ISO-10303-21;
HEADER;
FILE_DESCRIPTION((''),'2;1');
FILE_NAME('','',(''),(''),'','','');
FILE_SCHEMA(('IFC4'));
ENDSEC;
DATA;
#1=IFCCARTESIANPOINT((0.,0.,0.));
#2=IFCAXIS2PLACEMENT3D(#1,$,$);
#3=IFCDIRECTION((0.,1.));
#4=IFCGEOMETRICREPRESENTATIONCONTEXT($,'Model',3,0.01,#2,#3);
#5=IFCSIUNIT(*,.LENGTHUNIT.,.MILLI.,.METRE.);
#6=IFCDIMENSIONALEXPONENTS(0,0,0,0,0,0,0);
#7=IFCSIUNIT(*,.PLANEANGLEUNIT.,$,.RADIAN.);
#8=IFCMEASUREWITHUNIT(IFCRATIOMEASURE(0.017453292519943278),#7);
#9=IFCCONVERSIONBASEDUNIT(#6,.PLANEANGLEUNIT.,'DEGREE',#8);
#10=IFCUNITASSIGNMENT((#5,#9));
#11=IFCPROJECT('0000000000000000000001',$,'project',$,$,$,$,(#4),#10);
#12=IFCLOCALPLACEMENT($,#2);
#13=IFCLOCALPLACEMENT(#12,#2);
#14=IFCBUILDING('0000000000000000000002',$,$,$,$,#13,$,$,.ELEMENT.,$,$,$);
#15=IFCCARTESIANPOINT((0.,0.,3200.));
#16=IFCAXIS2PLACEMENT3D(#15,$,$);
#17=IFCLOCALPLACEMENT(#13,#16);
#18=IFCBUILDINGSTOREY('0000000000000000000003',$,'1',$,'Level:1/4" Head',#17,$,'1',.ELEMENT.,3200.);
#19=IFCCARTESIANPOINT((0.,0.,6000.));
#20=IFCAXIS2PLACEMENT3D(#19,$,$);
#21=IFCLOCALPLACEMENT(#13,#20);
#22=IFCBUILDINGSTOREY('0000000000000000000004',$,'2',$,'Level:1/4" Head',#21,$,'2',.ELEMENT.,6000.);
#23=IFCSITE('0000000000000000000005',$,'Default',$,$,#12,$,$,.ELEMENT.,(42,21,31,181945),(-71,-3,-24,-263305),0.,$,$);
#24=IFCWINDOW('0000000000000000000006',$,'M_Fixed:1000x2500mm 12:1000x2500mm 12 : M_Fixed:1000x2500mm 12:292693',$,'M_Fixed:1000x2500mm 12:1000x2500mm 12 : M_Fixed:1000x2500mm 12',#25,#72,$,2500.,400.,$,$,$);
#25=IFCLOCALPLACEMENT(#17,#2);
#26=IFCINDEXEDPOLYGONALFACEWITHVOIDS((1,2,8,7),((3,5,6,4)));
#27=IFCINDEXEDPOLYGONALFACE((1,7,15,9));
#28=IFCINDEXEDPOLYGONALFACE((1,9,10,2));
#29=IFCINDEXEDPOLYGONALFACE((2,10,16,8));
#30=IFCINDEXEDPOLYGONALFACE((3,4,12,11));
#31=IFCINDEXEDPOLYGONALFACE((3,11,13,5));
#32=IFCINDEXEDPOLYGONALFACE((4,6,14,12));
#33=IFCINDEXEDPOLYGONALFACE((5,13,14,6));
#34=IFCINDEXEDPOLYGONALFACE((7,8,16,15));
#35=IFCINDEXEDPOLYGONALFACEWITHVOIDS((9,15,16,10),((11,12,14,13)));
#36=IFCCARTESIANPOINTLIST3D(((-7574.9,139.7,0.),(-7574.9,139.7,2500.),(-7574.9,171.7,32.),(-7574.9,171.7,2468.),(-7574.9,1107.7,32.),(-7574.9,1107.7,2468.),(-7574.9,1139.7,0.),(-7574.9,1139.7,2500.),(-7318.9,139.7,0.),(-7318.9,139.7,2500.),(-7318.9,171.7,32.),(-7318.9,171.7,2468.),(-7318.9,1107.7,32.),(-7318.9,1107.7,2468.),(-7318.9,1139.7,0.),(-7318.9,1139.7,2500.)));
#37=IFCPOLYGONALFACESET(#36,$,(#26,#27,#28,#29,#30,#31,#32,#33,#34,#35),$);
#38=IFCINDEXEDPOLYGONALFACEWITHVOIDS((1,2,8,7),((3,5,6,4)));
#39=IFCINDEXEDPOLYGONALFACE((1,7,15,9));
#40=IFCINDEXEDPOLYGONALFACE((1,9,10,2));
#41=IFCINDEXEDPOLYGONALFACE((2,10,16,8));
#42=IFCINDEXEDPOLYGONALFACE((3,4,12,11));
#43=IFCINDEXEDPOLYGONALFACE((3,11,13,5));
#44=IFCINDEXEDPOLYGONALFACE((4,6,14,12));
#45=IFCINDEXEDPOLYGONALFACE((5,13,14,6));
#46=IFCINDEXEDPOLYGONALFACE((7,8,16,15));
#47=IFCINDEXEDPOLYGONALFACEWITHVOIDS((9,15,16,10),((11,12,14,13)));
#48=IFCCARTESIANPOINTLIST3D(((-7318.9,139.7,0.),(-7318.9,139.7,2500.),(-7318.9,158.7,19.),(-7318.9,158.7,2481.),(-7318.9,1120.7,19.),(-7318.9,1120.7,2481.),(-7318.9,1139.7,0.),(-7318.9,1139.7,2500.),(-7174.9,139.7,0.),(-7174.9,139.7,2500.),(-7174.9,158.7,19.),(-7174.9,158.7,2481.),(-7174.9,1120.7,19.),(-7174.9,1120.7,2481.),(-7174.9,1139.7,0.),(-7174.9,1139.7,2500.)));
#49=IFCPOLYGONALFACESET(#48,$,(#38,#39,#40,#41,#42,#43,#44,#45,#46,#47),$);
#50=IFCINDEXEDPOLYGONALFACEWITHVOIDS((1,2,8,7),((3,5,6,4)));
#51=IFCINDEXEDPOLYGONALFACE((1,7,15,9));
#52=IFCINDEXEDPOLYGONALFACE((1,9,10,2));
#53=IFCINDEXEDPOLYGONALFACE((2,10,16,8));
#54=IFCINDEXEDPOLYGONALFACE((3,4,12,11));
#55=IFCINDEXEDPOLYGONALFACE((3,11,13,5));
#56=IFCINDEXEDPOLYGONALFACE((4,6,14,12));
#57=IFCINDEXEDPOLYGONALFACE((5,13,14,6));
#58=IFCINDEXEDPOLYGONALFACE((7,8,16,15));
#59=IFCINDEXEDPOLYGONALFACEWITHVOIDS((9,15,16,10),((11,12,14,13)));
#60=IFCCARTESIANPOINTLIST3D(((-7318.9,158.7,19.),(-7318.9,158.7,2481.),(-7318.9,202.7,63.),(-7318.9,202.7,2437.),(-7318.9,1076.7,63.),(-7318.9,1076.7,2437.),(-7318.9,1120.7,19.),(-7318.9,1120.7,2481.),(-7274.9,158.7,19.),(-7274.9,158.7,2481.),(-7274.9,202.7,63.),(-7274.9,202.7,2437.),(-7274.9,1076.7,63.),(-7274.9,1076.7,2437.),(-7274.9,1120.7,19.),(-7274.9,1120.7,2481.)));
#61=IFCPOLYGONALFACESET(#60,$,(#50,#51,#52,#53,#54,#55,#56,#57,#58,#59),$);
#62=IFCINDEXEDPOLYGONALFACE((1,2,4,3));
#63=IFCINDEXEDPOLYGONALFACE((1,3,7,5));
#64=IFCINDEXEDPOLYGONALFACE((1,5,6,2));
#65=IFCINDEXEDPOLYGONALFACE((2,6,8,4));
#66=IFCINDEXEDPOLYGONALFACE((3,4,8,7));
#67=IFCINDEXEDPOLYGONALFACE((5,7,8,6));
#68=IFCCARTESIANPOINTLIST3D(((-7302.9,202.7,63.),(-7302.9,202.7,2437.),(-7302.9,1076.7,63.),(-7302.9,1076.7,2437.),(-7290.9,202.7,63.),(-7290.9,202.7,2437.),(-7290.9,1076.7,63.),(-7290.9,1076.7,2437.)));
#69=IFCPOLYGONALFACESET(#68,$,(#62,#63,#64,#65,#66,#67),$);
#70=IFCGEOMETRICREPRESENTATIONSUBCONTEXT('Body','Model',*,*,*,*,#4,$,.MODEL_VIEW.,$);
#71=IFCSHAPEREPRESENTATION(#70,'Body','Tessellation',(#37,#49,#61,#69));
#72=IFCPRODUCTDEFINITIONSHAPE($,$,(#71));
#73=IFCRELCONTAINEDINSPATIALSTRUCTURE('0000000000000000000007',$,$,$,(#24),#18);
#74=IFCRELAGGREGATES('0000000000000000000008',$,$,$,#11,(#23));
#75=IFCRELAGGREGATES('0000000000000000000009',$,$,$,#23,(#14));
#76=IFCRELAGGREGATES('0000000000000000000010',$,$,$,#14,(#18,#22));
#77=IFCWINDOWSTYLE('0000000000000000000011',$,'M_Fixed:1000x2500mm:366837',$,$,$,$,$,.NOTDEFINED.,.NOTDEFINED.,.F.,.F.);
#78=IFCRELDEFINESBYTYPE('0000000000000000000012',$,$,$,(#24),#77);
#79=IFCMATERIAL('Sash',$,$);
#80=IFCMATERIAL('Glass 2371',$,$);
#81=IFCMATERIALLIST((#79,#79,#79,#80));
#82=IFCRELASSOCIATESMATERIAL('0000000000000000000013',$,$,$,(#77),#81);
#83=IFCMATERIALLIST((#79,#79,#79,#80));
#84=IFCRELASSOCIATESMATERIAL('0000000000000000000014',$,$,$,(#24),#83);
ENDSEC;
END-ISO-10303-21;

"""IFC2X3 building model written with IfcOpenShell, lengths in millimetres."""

from ifc_helpers import new_model, entity, si_unit, converted_unit, direction, frame, frame_2d, origin, place, context, subcontext, project, spatial, polyline, rectangle, outline, extrude, source, transform, mapped, material, material_list, type_object, type_shapes, element, save


model = new_model("IFC2X3")

# Units and contexts
model_context = context("Model", 3, precision=0.01, world=origin(), true_north=direction((0.0, 1.0)))
body_context = subcontext(model_context, "Body", "Model", "MODEL_VIEW")
ifc_project = project(units=[si_unit("LENGTHUNIT", "METRE", prefix="MILLI"), converted_unit("PLANEANGLEUNIT", "DEGREE", entity("IfcRatioMeasure", 0.017453292519943278), si_unit("PLANEANGLEUNIT", "RADIAN"), dimensions=[0, 0, 0, 0, 0, 0, 0])], contexts=[model_context])

# Site, building, storey
site_placement = place(None, origin())
site = spatial("IfcSite", under=ifc_project, at=site_placement, Name="Default", CompositionType="ELEMENT", RefLatitude=(42, 21, 31, 181945), RefLongitude=(-71, -3, -24, -263305), RefElevation=0.0)
building_placement = place(site_placement, origin())
building = spatial("IfcBuilding", under=site, at=building_placement, CompositionType="ELEMENT")
storey_1_placement = place(building_placement, frame((0.0, 0.0, 3200.0)))
storey_1 = spatial("IfcBuildingStorey", under=building, at=storey_1_placement, Name="1", ObjectType="Level:1/4\" Head", LongName="1", CompositionType="ELEMENT", Elevation=3200.0)

# Shared definitions
storey_2_placement = place(building_placement, frame((0.0, 0.0, 6000.0)))
storey_2 = spatial("IfcBuildingStorey", under=building, at=storey_2_placement, Name="2", ObjectType="Level:1/4\" Head", LongName="2", CompositionType="ELEMENT", Elevation=6000.0)

# Shared definitions
ifc_material_1 = material(Name="Sash")
ifc_material_2 = material(Name="Glass 2371")

# Window
ifc_material_list_1 = material_list([ifc_material_1, ifc_material_1, ifc_material_1, ifc_material_2])
ifc_material_list_2 = material_list([ifc_material_1, ifc_material_1, ifc_material_1, ifc_material_2])
window_style_1 = type_object("IfcWindowStyle", Name="M_Fixed:1000x2500mm:366837", ConstructionType="NOTDEFINED", OperationType="NOTDEFINED", ParameterTakesPrecedence=False, Sizeable=False, material=ifc_material_list_2)
shared_shape_1 = source(origin(), body_context, "Body", "SweptSolid", [
    extrude(outline(polyline([(-1250.0, -500.0), (1250.0, -500.0), (1250.0, 500.0), (-1250.0, 500.0), (-1250.0, -500.0)]), holes=[polyline([(1218.0, 468.0), (1218.0, -468.0), (-1218.0, -468.0), (-1218.0, 468.0), (1218.0, 468.0)])]), frame((-7574.9, 639.7, 4450.0), z_axis=(1.0, 0.0, 0.0), x_axis=(0.0, 0.0, -1.0)), (0.0, 0.0, 1.0), 256.0),
    extrude(outline(polyline([(-1250.0, -500.0), (1250.0, -500.0), (1250.0, 500.0), (-1250.0, 500.0), (-1250.0, -500.0)]), holes=[polyline([(1231.0, 481.0), (1231.0, -481.0), (-1231.0, -481.0), (-1231.0, 481.0), (1231.0, 481.0)])]), frame((-7318.9, 639.7, 4450.0), z_axis=(1.0, 0.0, 0.0), x_axis=(0.0, 0.0, -1.0)), (0.0, 0.0, 1.0), 144.0),
    extrude(outline(polyline([(-1231.0, -481.0), (1231.0, -481.0), (1231.0, 481.0), (-1231.0, 481.0), (-1231.0, -481.0)]), holes=[polyline([(1187.0, 437.0), (1187.0, -437.0), (-1187.0, -437.0), (-1187.0, 437.0), (1187.0, 437.0)])]), frame((-7318.9, 639.7, 4450.0), z_axis=(1.0, 0.0, 0.0), x_axis=(0.0, 0.0, -1.0)), (0.0, 0.0, 1.0), 44.0),
    extrude(rectangle(XDim=874.0, YDim=12.0, at=frame_2d((0.0, 0.0), x_axis=(1.0, 0.0))), frame((-7296.9, 639.7, 3263.0), z_axis=(0.0, 0.0, 1.0), x_axis=(0.0, -1.0, 0.0)), (0.0, 0.0, 1.0), 2374.0),
])
type_shapes(window_style_1, [shared_shape_1])
window_1_placement = place(storey_1_placement, frame((0.0, 0.0, -3200.0)))
element("IfcWindow", 1, at=window_1_placement, inside=storey_1, type_object=window_style_1, material=ifc_material_list_1, Name="M_Fixed:1000x2500mm 12:1000x2500mm 12 : M_Fixed:1000x2500mm 12:292693", ObjectType="M_Fixed:1000x2500mm 12:1000x2500mm 12 : M_Fixed:1000x2500mm 12", OverallHeight=2500.0, OverallWidth=400.0, context=body_context, shape_type="MappedRepresentation", body=[
    mapped(shared_shape_1, transform((0.0, 0.0, 0.0), scale=1.0)),
])

save(model, "model.ifc")
